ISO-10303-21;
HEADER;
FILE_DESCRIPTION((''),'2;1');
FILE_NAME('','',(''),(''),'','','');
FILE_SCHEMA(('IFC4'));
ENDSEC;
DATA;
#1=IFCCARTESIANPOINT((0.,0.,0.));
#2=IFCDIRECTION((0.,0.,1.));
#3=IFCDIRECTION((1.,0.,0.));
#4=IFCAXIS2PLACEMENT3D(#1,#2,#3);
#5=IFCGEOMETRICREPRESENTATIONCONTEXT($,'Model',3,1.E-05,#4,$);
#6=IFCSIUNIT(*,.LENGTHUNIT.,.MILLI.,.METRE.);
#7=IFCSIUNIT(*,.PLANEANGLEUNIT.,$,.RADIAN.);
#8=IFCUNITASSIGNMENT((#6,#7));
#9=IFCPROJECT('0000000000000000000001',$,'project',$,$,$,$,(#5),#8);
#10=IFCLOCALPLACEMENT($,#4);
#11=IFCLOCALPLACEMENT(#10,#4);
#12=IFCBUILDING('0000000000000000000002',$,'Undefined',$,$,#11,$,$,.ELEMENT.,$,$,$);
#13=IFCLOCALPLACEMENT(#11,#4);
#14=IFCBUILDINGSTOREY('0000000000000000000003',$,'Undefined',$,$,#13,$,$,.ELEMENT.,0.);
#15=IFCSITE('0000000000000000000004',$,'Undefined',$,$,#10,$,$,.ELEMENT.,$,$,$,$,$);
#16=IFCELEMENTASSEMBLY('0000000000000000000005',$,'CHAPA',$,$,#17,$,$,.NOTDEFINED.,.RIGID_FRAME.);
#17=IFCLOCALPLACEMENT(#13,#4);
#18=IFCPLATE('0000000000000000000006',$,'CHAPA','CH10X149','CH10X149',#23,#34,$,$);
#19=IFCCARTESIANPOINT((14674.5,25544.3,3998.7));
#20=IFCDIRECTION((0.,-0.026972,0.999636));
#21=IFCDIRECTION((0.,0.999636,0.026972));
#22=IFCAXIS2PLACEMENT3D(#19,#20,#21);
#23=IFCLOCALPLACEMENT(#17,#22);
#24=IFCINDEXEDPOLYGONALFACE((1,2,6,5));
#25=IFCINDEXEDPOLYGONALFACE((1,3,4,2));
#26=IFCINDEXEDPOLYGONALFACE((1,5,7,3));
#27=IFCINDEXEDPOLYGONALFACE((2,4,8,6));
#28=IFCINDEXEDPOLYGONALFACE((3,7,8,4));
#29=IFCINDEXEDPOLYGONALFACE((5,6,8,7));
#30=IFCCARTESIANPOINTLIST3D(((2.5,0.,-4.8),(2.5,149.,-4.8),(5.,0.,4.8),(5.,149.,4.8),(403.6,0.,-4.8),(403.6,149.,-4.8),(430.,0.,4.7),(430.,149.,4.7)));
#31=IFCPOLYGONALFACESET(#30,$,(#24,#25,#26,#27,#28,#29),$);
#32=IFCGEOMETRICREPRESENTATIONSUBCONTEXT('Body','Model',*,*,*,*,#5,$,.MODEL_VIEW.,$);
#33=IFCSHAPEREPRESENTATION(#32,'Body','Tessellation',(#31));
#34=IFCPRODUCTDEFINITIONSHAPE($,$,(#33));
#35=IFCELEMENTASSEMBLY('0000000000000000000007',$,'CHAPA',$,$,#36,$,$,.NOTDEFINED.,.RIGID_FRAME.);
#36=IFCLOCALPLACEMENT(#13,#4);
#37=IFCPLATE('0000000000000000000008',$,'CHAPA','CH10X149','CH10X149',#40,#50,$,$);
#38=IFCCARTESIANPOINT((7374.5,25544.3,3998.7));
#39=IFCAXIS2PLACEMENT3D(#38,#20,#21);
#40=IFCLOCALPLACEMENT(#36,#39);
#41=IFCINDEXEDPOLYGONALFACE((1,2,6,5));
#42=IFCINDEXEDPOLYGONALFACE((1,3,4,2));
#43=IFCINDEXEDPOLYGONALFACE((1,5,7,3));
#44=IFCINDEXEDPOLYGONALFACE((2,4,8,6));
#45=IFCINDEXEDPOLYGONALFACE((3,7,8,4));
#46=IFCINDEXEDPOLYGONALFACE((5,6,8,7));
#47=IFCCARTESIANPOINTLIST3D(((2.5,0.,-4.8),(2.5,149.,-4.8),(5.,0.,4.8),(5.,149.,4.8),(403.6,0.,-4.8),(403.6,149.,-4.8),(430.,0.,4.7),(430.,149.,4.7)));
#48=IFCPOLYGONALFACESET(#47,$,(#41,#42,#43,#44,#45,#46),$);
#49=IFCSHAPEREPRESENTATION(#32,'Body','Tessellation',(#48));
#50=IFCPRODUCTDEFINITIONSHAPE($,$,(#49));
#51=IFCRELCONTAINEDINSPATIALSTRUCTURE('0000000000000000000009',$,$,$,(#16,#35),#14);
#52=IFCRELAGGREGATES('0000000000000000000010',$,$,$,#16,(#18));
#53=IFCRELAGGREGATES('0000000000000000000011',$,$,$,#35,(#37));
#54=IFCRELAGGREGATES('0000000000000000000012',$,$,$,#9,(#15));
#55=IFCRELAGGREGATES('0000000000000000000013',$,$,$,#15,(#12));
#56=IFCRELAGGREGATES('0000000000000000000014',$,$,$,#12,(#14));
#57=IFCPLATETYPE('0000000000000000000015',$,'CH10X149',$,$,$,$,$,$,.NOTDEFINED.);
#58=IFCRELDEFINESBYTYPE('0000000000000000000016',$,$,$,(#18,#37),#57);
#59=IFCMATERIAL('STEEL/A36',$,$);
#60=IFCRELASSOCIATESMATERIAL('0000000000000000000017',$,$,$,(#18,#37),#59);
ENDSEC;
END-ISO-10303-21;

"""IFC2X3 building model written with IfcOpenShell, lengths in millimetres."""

from ifc_helpers import new_model, si_unit, frame, origin_with_axes, place, context, subcontext, project, spatial, polyline, outline, extrude, clip, halfspace, material, type_object, element, aggregate, save


model = new_model("IFC2X3")

# Units and contexts
model_context = context("Model", 3, precision=1e-05, world=origin_with_axes())
body_context = subcontext(model_context, "Body", "Model", "MODEL_VIEW")
ifc_project = project(units=[si_unit("LENGTHUNIT", "METRE", prefix="MILLI"), si_unit("PLANEANGLEUNIT", "RADIAN")], contexts=[model_context])

# Site, building, storey
site_placement = place(None, origin_with_axes())
site = spatial("IfcSite", under=ifc_project, at=site_placement, Name="Undefined", CompositionType="ELEMENT")
building_placement = place(site_placement, origin_with_axes())
building = spatial("IfcBuilding", under=site, at=building_placement, Name="Undefined", CompositionType="ELEMENT")
storey_placement = place(building_placement, origin_with_axes())
storey = spatial("IfcBuildingStorey", under=building, at=storey_placement, Name="Undefined", CompositionType="ELEMENT", Elevation=0.0)

# Shared definitions
ifc_material_1 = material(Name="STEEL/A36")

# Element assemblies, plates
plate_type_1 = type_object("IfcPlateType", Name="CH10X149", PredefinedType="NOTDEFINED")
assembly_1_placement = place(storey_placement, origin_with_axes())
assembly_1 = element("IfcElementAssembly", 1, at=assembly_1_placement, inside=storey, Name="CHAPA", AssemblyPlace="NOTDEFINED", PredefinedType="RIGID_FRAME")
plate_1_placement = place(assembly_1_placement, frame((14674.5, 25544.3, 3998.7), z_axis=(0.0, -0.026972, 0.999636), x_axis=(0.0, 0.999636, 0.026972)))
plate_1 = element("IfcPlate", 2, at=plate_1_placement, type_object=plate_type_1, material=ifc_material_1, Name="CHAPA", Description="CH10X149", ObjectType="CH10X149", context=body_context, shape_type="Clipping", body=[
    clip(clip(extrude(outline(polyline([(0.0, 0.0), (430.0, 0.0), (430.0, 149.0), (0.0, 149.0), (0.0, 0.0)])), frame((0.0, 0.0, -4.8), z_axis=(0.0, 0.0, 1.0), x_axis=(1.0, 0.0, 0.0)), (0.0, 0.0, 1.0), 9.5), halfspace(frame((403.6, -500.0, -4.8), z_axis=(0.33881, 0.0, -0.940855), x_axis=(0.940855, 0.0, 0.33881)), False)), halfspace(frame((5.0, -500.0, 4.7), z_axis=(-0.965989, 0.0, 0.258583), x_axis=(-0.258583, 0.0, -0.965989)), False)),
])
aggregate(assembly_1, [plate_1])
assembly_2_placement = place(storey_placement, origin_with_axes())
assembly_2 = element("IfcElementAssembly", 3, at=assembly_2_placement, inside=storey, Name="CHAPA", AssemblyPlace="NOTDEFINED", PredefinedType="RIGID_FRAME")
plate_2_placement = place(assembly_2_placement, frame((7374.5, 25544.3, 3998.7), z_axis=(0.0, -0.026972, 0.999636), x_axis=(0.0, 0.999636, 0.026972)))
plate_2 = element("IfcPlate", 4, at=plate_2_placement, type_object=plate_type_1, material=ifc_material_1, Name="CHAPA", Description="CH10X149", ObjectType="CH10X149", context=body_context, shape_type="Clipping", body=[
    clip(clip(extrude(outline(polyline([(0.0, 0.0), (430.0, 0.0), (430.0, 149.0), (0.0, 149.0), (0.0, 0.0)])), frame((0.0, 0.0, -4.8), z_axis=(0.0, 0.0, 1.0), x_axis=(1.0, 0.0, 0.0)), (0.0, 0.0, 1.0), 9.5), halfspace(frame((403.6, -500.0, -4.8), z_axis=(0.33881, 0.0, -0.940855), x_axis=(0.940855, 0.0, 0.33881)), False)), halfspace(frame((5.0, -500.0, 4.7), z_axis=(-0.965989, 0.0, 0.258583), x_axis=(-0.258583, 0.0, -0.965989)), False)),
])
aggregate(assembly_2, [plate_2])

save(model, "model.ifc")
